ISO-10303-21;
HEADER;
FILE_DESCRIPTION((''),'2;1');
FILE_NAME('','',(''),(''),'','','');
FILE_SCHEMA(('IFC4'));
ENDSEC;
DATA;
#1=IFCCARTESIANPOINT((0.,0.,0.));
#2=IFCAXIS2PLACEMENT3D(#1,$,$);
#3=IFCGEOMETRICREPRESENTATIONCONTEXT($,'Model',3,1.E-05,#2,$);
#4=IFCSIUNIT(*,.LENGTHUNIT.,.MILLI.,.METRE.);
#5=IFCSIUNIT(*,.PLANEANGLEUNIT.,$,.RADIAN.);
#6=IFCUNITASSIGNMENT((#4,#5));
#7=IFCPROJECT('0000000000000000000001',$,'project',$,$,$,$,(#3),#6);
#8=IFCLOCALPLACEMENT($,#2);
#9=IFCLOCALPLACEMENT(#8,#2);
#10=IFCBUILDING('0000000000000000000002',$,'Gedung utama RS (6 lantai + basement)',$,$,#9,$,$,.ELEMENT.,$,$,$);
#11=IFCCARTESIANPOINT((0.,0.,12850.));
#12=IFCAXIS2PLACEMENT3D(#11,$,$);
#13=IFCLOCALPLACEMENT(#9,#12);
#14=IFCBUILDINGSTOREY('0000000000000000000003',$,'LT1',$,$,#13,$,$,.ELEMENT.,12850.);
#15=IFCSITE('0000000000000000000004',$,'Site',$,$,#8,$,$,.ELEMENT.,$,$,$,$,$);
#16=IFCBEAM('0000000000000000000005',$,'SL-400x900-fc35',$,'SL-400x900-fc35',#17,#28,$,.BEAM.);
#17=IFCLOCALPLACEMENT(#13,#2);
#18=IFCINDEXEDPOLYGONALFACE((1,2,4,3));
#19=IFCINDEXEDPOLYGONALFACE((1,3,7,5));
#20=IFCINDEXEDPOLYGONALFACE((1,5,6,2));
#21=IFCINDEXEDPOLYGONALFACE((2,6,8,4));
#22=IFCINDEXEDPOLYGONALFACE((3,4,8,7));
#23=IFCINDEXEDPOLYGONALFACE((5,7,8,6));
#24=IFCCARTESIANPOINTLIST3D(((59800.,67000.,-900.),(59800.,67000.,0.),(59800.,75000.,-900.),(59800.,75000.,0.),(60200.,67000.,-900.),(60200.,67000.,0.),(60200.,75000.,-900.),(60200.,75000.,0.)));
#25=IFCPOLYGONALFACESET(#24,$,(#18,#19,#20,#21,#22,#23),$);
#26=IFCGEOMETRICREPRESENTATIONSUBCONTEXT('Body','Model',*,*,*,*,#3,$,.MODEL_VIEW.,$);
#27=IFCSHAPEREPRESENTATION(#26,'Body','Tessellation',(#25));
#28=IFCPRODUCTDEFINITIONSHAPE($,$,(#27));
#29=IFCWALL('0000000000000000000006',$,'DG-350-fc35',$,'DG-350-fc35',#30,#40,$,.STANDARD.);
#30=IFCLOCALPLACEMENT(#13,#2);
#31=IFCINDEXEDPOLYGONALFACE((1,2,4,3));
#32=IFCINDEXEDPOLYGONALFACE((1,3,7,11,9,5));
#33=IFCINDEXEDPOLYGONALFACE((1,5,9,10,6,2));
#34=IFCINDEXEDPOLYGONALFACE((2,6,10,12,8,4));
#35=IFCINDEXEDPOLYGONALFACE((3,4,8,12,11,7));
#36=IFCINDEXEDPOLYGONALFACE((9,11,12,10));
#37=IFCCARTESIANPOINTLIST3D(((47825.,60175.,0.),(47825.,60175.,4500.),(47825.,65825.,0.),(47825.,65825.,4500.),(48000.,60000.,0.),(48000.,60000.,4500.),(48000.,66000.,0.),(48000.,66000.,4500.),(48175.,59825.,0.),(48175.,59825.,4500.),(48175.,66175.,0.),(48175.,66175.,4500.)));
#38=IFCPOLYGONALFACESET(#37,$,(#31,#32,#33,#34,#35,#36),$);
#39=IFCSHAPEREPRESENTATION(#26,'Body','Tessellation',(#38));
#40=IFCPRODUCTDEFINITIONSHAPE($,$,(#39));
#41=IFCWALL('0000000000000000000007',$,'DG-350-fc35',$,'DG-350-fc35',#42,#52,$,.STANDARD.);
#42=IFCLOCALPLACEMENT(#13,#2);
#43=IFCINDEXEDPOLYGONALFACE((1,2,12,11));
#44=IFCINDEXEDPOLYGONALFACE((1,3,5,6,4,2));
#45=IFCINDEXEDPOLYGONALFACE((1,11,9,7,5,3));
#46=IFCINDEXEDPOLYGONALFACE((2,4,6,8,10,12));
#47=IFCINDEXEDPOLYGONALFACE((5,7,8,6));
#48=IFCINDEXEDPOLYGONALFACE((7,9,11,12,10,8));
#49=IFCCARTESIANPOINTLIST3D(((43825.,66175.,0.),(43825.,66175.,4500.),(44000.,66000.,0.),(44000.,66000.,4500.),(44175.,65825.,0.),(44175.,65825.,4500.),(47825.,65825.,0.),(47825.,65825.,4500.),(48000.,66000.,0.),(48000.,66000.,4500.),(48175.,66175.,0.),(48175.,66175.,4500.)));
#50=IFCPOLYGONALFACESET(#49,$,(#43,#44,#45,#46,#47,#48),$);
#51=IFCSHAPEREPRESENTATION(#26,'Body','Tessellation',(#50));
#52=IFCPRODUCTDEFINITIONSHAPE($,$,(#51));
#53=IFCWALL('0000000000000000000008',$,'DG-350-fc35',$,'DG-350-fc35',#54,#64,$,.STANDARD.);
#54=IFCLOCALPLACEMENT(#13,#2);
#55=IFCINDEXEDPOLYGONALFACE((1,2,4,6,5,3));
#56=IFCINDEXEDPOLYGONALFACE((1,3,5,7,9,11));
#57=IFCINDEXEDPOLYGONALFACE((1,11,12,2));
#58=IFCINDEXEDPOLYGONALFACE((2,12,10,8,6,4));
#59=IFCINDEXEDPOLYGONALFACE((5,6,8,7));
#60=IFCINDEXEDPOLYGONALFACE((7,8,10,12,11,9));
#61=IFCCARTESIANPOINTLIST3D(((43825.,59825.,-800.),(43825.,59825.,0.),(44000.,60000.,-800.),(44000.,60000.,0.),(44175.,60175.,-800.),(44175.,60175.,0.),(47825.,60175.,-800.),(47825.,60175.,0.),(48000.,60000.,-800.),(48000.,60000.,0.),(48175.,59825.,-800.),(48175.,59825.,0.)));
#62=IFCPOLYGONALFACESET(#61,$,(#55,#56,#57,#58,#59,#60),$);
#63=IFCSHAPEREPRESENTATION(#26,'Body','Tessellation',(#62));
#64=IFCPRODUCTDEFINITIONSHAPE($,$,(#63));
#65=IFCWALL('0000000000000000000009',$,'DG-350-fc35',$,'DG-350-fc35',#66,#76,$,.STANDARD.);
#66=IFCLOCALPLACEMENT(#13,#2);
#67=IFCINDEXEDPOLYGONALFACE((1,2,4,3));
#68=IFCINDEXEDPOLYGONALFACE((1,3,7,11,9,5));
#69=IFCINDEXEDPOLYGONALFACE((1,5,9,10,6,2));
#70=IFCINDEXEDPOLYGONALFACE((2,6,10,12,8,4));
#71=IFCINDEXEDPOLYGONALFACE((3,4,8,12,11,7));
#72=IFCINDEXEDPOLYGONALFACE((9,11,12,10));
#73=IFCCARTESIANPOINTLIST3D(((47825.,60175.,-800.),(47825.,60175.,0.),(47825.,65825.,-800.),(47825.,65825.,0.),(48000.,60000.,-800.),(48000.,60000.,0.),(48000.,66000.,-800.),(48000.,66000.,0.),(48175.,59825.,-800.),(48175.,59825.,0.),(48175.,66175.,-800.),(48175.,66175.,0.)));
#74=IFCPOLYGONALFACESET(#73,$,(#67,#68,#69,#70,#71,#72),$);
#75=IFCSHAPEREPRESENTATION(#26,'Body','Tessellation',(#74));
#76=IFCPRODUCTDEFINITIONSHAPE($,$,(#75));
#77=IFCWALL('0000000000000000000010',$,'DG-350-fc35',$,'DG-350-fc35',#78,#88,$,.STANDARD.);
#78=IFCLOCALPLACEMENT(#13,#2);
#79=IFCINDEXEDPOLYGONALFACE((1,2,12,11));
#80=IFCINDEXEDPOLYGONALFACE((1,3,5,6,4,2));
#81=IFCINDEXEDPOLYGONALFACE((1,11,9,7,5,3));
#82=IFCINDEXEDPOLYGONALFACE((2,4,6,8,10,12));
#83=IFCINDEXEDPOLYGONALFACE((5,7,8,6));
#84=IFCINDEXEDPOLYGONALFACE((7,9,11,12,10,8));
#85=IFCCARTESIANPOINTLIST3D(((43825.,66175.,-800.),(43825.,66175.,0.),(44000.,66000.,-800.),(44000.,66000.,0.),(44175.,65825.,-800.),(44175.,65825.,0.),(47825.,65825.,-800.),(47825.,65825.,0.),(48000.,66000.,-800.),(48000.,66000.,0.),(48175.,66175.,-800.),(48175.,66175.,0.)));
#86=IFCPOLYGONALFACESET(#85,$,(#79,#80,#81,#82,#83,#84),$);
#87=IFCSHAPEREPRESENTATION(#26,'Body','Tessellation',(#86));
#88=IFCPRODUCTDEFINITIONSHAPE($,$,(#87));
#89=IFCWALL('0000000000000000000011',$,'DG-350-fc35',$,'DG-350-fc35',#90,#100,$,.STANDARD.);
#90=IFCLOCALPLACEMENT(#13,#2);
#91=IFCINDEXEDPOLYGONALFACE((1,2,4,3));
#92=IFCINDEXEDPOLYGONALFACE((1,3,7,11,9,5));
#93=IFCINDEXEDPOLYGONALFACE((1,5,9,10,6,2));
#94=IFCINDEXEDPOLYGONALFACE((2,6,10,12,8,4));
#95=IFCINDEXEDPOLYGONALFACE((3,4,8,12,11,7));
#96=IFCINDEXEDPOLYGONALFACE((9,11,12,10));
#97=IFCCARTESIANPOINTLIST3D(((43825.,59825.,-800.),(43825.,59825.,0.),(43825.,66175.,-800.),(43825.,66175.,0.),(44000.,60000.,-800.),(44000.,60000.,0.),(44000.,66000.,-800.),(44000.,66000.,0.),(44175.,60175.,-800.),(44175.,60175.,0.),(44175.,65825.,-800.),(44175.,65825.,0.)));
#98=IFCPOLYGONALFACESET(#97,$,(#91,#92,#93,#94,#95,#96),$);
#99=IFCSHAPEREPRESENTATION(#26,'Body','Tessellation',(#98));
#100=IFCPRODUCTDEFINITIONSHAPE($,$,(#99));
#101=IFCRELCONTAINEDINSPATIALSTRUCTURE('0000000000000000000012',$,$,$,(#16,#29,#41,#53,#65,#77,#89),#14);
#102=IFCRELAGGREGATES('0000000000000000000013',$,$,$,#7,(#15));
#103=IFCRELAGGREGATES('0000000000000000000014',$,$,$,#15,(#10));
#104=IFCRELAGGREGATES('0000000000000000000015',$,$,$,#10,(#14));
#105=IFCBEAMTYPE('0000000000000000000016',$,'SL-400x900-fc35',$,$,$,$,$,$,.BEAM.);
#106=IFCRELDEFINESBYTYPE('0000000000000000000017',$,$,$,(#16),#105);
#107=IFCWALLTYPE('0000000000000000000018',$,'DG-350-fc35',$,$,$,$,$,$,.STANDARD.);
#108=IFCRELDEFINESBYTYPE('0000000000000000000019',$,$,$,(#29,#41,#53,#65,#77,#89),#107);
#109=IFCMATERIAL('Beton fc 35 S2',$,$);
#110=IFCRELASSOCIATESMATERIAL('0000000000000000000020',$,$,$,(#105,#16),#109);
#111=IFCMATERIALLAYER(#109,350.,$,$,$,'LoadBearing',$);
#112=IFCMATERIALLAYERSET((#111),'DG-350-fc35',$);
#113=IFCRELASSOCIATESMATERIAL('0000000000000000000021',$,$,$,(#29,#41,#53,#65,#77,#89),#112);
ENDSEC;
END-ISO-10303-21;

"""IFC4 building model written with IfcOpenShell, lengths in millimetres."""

from ifc_helpers import new_model, si_unit, frame, origin, origin_2d, place, context, subcontext, project, spatial, polyline, rectangle, outline, extrude, material, layer, layer_set, layer_usage, material_profile, profile_set, profile_usage, type_object, element, save


model = new_model("IFC4")

# Units and contexts
model_context = context("Model", 3, precision=1e-05, world=origin())
body_context = subcontext(model_context, "Body", "Model", "MODEL_VIEW")
ifc_project = project(units=[si_unit("LENGTHUNIT", "METRE", prefix="MILLI"), si_unit("PLANEANGLEUNIT", "RADIAN")], contexts=[model_context])

# Site, building, storey
site_placement = place(None, origin())
site = spatial("IfcSite", under=ifc_project, at=site_placement, Name="Site", CompositionType="ELEMENT")
building_placement = place(site_placement, origin())
building = spatial("IfcBuilding", under=site, at=building_placement, Name="Gedung utama RS (6 lantai + basement)", CompositionType="ELEMENT")
storey_placement = place(building_placement, frame((0.0, 0.0, 12850.0)))
storey = spatial("IfcBuildingStorey", under=building, at=storey_placement, Name="LT1", CompositionType="ELEMENT", Elevation=12850.0)

# Beam
ifc_material = material(Name="Beton fc 35 S2")
ifc_material_profile_1 = material_profile(ifc_material, rectangle(XDim=400.0, YDim=900.0, at=origin_2d()), Name="SL-400x900-fc35")
ifc_profile_set_1 = profile_set([ifc_material_profile_1], Name="SL-400x900-fc35")
ifc_profile_usage_1 = profile_usage(ifc_profile_set_1, cardinal=8)
beam_type_1 = type_object("IfcBeamType", Name="SL-400x900-fc35", PredefinedType="BEAM", material=ifc_profile_set_1)
beam_1_placement = place(storey_placement, frame((60000.0, 67000.0, -450.0)))
element("IfcBeam", 1, at=beam_1_placement, inside=storey, type_object=beam_type_1, material=ifc_profile_usage_1, Name="SL-400x900-fc35", ObjectType="SL-400x900-fc35", PredefinedType="BEAM", context=body_context, shape_type="SweptSolid", body=[
    extrude(rectangle(XDim=400.0, YDim=900.0, at=origin_2d()), frame((0.0, 0.0, 0.0), z_axis=(0.0, 1.0, 0.0), x_axis=(-1.0, 0.0, 0.0)), (0.0, 0.0, 1.0), 8000.0),
])

# Walls
ifc_layer = layer(ifc_material, 350.0, Category="LoadBearing")
ifc_layer_set = layer_set([ifc_layer], Name="DG-350-fc35")
ifc_layer_usage = layer_usage(ifc_layer_set, "AXIS2", "NEGATIVE", 175.0)
wall_type = type_object("IfcWallType", Name="DG-350-fc35", PredefinedType="STANDARD")
wall_1_placement = place(storey_placement, frame((48000.0, 60000.0, 0.0), z_axis=(0.0, 0.0, 1.0), x_axis=(0.0, 1.0, 0.0)))
element("IfcWall", 2, at=wall_1_placement, inside=storey, type_object=wall_type, material=ifc_layer_usage, Name="DG-350-fc35", ObjectType="DG-350-fc35", PredefinedType="STANDARD", context=body_context, shape_type="SweptSolid", body=[
    extrude(outline(polyline([(-175.0, -175.0), (0.0, 0.0), (175.0, 175.0), (5825.0, 175.0), (6000.0, 0.0), (6175.0, -175.0), (-175.0, -175.0)])), origin(), (0.0, 0.0, 1.0), 4500.0),
])
wall_2_placement = place(storey_placement, frame((48000.0, 66000.0, 0.0), z_axis=(0.0, 0.0, 1.0), x_axis=(-1.0, 0.0, 0.0)))
element("IfcWall", 3, at=wall_2_placement, inside=storey, type_object=wall_type, material=ifc_layer_usage, Name="DG-350-fc35", ObjectType="DG-350-fc35", PredefinedType="STANDARD", context=body_context, shape_type="SweptSolid", body=[
    extrude(outline(polyline([(-175.0, -175.0), (0.0, 0.0), (175.0, 175.0), (3825.0, 175.0), (4000.0, 0.0), (4175.0, -175.0), (-175.0, -175.0)])), origin(), (0.0, 0.0, 1.0), 4500.0),
])
wall_3_placement = place(storey_placement, frame((44000.0, 60000.0, -800.0), z_axis=(0.0, 0.0, 1.0), x_axis=(1.0, 0.0, 0.0)))
element("IfcWall", 4, at=wall_3_placement, inside=storey, type_object=wall_type, material=ifc_layer_usage, Name="DG-350-fc35", ObjectType="DG-350-fc35", PredefinedType="STANDARD", context=body_context, shape_type="SweptSolid", body=[
    extrude(outline(polyline([(-175.0, -175.0), (0.0, 0.0), (175.0, 175.0), (3825.0, 175.0), (4000.0, 0.0), (4175.0, -175.0), (-175.0, -175.0)])), origin(), (0.0, 0.0, 1.0), 800.0),
])
wall_4_placement = place(storey_placement, frame((48000.0, 60000.0, -800.0), z_axis=(0.0, 0.0, 1.0), x_axis=(0.0, 1.0, 0.0)))
element("IfcWall", 5, at=wall_4_placement, inside=storey, type_object=wall_type, material=ifc_layer_usage, Name="DG-350-fc35", ObjectType="DG-350-fc35", PredefinedType="STANDARD", context=body_context, shape_type="SweptSolid", body=[
    extrude(outline(polyline([(-175.0, -175.0), (0.0, 0.0), (175.0, 175.0), (5825.0, 175.0), (6000.0, 0.0), (6175.0, -175.0), (-175.0, -175.0)])), origin(), (0.0, 0.0, 1.0), 800.0),
])
wall_5_placement = place(storey_placement, frame((48000.0, 66000.0, -800.0), z_axis=(0.0, 0.0, 1.0), x_axis=(-1.0, 0.0, 0.0)))
element("IfcWall", 6, at=wall_5_placement, inside=storey, type_object=wall_type, material=ifc_layer_usage, Name="DG-350-fc35", ObjectType="DG-350-fc35", PredefinedType="STANDARD", context=body_context, shape_type="SweptSolid", body=[
    extrude(outline(polyline([(-175.0, -175.0), (0.0, 0.0), (175.0, 175.0), (3825.0, 175.0), (4000.0, 0.0), (4175.0, -175.0), (-175.0, -175.0)])), origin(), (0.0, 0.0, 1.0), 800.0),
])
wall_6_placement = place(storey_placement, frame((44000.0, 66000.0, -800.0), z_axis=(0.0, 0.0, 1.0), x_axis=(0.0, -1.0, 0.0)))
element("IfcWall", 7, at=wall_6_placement, inside=storey, type_object=wall_type, material=ifc_layer_usage, Name="DG-350-fc35", ObjectType="DG-350-fc35", PredefinedType="STANDARD", context=body_context, shape_type="SweptSolid", body=[
    extrude(outline(polyline([(-175.0, -175.0), (0.0, 0.0), (175.0, 175.0), (5825.0, 175.0), (6000.0, 0.0), (6175.0, -175.0), (-175.0, -175.0)])), origin(), (0.0, 0.0, 1.0), 800.0),
])

save(model, "model.ifc")
